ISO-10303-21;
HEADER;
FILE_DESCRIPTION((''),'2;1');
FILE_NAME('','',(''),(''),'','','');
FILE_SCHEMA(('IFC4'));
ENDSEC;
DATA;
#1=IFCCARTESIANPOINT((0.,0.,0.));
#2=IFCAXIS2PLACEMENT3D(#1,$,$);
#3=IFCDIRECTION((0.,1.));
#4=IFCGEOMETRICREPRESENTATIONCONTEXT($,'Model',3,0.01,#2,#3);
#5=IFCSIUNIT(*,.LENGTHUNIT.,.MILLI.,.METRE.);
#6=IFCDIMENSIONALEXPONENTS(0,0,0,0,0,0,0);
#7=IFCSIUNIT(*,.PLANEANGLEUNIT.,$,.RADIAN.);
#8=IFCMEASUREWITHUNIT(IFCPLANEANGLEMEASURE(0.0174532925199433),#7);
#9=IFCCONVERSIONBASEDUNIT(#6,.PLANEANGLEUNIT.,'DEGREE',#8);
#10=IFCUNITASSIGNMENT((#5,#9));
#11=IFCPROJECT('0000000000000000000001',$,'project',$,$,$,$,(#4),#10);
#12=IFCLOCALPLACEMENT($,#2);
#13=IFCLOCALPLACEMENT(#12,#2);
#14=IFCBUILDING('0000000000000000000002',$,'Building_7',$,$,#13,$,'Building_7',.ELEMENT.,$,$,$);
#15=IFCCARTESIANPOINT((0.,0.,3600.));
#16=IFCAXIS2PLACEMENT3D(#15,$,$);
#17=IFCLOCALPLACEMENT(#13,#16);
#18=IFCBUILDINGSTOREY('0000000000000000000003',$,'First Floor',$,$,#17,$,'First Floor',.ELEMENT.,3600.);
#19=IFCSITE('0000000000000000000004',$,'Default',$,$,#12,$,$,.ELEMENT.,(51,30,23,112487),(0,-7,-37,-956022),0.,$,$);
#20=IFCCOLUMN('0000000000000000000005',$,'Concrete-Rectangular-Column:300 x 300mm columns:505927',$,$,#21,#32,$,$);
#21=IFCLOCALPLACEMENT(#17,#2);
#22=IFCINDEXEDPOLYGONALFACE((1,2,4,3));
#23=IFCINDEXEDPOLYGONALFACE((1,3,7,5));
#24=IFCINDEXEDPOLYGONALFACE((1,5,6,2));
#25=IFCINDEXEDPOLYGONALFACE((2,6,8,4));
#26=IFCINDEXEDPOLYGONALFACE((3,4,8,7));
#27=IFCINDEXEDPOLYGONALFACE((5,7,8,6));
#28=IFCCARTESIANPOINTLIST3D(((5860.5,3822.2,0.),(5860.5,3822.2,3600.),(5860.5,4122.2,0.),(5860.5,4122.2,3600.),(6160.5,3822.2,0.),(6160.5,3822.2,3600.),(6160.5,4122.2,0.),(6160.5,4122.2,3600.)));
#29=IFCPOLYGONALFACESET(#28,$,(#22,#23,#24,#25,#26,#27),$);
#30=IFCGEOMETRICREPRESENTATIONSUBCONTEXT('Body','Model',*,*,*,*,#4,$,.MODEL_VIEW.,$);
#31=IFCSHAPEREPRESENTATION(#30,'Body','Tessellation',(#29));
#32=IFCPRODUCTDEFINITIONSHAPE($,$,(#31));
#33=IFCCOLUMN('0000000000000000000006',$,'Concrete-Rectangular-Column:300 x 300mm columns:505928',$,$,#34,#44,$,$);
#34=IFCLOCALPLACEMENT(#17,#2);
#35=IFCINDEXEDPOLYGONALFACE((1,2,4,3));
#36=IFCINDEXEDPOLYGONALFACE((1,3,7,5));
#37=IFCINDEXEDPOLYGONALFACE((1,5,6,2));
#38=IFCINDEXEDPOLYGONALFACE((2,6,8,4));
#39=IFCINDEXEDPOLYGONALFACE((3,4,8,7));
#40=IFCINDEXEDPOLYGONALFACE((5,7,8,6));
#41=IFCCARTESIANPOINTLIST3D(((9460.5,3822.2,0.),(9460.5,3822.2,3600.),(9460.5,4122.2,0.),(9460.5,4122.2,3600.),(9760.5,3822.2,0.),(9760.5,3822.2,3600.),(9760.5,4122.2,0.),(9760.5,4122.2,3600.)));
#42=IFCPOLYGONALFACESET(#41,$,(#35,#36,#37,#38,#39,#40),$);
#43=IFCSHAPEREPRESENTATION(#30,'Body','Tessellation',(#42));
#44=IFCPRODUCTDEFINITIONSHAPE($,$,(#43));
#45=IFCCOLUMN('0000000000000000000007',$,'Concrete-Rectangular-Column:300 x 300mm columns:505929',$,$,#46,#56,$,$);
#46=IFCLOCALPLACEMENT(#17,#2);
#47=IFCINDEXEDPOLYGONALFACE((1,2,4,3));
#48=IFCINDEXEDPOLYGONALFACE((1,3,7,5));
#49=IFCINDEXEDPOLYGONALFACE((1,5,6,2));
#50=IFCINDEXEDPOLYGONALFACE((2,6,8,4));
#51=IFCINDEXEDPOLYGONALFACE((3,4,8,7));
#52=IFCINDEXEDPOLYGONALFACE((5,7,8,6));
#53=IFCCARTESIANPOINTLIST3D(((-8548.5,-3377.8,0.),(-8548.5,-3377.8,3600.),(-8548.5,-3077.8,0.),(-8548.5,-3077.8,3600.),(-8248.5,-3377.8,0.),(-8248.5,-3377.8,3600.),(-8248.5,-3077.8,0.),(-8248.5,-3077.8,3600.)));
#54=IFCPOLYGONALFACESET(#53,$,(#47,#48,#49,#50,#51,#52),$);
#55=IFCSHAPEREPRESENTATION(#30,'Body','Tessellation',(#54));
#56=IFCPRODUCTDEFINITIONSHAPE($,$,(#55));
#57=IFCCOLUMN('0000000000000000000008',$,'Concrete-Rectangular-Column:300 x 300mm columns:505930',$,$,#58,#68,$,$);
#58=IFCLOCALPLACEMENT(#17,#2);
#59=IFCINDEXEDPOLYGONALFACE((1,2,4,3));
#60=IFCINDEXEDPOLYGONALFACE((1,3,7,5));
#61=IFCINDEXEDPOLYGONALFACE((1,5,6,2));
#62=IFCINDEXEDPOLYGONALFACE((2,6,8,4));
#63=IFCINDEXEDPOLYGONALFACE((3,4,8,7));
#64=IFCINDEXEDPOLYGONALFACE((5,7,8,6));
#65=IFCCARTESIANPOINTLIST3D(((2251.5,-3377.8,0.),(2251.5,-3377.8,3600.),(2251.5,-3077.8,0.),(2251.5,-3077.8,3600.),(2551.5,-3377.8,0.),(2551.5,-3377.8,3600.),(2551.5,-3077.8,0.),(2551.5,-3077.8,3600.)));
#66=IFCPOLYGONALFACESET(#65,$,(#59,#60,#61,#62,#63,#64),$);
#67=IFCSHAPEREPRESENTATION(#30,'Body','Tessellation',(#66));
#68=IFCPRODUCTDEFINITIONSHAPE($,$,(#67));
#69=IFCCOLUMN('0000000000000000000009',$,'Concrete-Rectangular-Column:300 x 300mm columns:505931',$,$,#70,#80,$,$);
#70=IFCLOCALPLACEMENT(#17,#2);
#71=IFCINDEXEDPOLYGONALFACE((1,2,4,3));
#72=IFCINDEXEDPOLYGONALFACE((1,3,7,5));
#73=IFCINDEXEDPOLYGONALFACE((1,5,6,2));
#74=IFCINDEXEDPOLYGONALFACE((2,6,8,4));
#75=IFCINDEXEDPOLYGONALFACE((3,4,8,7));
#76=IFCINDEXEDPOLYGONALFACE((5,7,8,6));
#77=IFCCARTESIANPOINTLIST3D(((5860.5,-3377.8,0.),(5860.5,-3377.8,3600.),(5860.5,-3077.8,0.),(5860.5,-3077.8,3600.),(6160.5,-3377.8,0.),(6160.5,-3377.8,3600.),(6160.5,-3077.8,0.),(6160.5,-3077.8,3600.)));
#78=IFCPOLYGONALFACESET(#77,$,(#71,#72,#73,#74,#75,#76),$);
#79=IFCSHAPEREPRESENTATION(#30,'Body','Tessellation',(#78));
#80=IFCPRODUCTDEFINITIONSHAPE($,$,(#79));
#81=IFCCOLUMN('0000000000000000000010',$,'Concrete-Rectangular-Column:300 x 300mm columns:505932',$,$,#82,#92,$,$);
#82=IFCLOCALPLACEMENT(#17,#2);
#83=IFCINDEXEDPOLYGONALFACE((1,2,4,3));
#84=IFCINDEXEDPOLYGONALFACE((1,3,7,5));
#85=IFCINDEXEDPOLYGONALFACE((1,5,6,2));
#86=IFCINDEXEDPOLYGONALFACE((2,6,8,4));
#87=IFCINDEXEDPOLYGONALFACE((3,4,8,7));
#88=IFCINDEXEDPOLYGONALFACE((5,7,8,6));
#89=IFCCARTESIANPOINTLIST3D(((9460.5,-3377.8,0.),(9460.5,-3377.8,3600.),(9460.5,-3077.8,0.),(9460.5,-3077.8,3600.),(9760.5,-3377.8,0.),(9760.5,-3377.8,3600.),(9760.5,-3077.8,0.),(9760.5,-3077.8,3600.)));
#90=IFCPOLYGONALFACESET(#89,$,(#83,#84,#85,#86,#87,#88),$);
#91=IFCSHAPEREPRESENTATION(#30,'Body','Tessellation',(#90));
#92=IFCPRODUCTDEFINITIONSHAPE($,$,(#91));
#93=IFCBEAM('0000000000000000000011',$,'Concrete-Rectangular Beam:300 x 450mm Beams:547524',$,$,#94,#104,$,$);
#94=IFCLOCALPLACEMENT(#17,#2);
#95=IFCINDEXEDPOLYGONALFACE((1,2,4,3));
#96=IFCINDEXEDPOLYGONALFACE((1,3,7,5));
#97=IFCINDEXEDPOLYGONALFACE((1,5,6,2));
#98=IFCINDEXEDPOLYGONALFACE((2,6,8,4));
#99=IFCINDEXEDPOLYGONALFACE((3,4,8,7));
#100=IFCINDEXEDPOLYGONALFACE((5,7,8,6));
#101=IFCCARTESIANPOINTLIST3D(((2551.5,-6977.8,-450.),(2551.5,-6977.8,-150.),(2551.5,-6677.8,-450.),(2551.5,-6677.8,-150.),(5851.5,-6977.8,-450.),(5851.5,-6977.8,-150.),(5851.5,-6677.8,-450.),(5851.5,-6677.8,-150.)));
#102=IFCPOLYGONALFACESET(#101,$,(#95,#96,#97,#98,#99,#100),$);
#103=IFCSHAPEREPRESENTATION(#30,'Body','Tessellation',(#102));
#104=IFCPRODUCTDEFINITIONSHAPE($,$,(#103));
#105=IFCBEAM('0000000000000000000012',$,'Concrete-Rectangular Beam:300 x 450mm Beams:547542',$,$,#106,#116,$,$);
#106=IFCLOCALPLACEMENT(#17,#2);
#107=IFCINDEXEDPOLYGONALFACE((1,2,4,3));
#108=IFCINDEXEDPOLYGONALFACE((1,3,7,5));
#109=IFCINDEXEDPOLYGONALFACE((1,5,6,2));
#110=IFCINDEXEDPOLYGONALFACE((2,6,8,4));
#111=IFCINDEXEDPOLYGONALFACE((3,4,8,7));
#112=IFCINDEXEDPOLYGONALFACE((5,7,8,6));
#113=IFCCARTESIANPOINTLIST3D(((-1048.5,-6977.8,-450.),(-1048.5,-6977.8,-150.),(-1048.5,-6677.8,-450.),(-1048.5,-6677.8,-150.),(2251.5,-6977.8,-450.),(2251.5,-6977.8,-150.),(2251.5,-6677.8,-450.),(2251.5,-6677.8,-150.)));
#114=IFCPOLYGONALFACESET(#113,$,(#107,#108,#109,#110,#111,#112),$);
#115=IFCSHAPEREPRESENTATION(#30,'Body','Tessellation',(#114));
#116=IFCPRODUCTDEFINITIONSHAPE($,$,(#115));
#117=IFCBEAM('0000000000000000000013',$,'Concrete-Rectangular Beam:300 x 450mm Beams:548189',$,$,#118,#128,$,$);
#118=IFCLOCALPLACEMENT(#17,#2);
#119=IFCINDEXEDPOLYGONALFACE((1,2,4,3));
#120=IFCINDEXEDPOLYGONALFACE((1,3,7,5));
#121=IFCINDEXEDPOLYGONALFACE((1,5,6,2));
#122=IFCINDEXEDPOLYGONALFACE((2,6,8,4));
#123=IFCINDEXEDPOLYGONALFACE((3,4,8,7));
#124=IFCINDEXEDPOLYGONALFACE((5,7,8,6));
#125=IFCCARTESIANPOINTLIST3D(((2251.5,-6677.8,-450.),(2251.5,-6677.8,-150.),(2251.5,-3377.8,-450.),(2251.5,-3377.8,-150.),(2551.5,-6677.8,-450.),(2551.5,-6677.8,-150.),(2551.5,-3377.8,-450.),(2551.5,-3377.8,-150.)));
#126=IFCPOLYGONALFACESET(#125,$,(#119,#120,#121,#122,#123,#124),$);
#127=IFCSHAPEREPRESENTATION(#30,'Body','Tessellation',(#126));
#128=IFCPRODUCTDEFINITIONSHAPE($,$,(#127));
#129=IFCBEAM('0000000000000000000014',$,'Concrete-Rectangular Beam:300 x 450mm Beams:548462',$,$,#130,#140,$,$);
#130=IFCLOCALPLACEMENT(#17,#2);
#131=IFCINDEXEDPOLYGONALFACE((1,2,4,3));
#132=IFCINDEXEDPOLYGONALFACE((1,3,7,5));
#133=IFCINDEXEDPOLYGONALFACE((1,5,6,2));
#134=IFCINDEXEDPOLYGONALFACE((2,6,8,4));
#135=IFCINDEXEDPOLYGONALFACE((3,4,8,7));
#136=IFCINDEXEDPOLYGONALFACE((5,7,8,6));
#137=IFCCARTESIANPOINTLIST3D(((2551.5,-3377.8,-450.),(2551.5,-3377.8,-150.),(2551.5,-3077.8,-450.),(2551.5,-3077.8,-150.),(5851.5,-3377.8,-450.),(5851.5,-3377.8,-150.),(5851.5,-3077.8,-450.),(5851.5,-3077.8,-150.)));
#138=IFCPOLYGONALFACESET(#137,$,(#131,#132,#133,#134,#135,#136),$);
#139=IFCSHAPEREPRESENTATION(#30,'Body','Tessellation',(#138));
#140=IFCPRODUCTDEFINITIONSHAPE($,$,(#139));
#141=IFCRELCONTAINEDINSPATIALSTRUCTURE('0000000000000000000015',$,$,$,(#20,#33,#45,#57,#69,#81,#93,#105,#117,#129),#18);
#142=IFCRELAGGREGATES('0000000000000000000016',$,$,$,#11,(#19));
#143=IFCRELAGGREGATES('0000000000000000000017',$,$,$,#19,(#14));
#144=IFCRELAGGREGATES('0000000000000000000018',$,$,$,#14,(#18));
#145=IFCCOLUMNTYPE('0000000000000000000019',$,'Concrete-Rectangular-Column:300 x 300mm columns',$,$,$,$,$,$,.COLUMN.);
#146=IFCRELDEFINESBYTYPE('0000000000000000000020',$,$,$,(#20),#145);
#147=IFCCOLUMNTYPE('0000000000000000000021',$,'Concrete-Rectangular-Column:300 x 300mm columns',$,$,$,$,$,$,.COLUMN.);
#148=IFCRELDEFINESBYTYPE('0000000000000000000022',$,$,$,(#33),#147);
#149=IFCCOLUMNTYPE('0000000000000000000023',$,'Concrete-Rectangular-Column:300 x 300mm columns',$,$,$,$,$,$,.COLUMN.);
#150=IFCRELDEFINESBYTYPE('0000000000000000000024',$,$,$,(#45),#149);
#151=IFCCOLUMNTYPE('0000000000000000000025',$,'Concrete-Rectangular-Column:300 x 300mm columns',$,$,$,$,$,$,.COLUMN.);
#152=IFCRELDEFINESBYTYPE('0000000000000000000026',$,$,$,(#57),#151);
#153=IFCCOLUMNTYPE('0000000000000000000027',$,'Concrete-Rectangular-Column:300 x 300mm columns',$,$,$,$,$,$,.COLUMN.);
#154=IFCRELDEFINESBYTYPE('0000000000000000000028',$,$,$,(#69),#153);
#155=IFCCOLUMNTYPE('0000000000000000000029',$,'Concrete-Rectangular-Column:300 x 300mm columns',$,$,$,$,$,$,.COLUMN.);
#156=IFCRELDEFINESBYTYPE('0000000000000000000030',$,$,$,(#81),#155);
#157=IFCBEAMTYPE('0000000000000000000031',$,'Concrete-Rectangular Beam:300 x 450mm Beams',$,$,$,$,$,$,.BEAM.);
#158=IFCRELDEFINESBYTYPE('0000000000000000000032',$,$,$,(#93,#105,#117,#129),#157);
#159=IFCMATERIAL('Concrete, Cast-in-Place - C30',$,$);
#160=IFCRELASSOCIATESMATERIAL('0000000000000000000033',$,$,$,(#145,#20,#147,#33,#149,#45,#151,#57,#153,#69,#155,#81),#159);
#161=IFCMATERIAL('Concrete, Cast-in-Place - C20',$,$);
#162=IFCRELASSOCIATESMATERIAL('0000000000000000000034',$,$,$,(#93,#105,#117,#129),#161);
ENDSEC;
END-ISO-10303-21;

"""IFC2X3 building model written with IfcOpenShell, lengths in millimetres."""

from ifc_helpers import new_model, entity, si_unit, converted_unit, direction, frame, frame_2d, origin, origin_2d_with_axis, place, context, subcontext, project, spatial, rectangle, extrude, source, transform, mapped, material, type_object, type_shapes, element, save


model = new_model("IFC2X3")

# Units and contexts
model_context = context("Model", 3, precision=0.01, world=origin(), true_north=direction((0.0, 1.0)))
body_context = subcontext(model_context, "Body", "Model", "MODEL_VIEW")
ifc_project = project(units=[si_unit("LENGTHUNIT", "METRE", prefix="MILLI"), converted_unit("PLANEANGLEUNIT", "DEGREE", entity("IfcPlaneAngleMeasure", 0.0174532925199433), si_unit("PLANEANGLEUNIT", "RADIAN"), dimensions=[0, 0, 0, 0, 0, 0, 0])], contexts=[model_context])

# Site, building, storey
site_placement = place(None, origin())
site = spatial("IfcSite", under=ifc_project, at=site_placement, Name="Default", CompositionType="ELEMENT", RefLatitude=(51, 30, 23, 112487), RefLongitude=(0, -7, -37, -956022), RefElevation=0.0)
building_placement = place(site_placement, origin())
building = spatial("IfcBuilding", under=site, at=building_placement, Name="Building_7", LongName="Building_7", CompositionType="ELEMENT")
storey_placement = place(building_placement, frame((0.0, 0.0, 3600.0)))
storey = spatial("IfcBuildingStorey", under=building, at=storey_placement, Name="First Floor", LongName="First Floor", CompositionType="ELEMENT", Elevation=3600.0)

# Columns
ifc_material_1 = material(Name="Concrete, Cast-in-Place - C30")
column_type_1 = type_object("IfcColumnType", Name="Concrete-Rectangular-Column:300 x 300mm columns", PredefinedType="COLUMN", material=ifc_material_1)
shared_shape_1 = source(origin(), body_context, "Body", "SweptSolid", [
    extrude(rectangle(XDim=300.0, YDim=300.0, at=frame_2d((0.0, 0.0), x_axis=(1.0, 0.0))), frame((6010.5, 3972.2, 3600.0), z_axis=(0.0, 0.0, 1.0), x_axis=(-1.0, 0.0, 0.0)), (0.0, 0.0, 1.0), 3600.0),
])
type_shapes(column_type_1, [shared_shape_1])
column_1_placement = place(storey_placement, frame((0.0, 0.0, -3600.0)))
element("IfcColumn", 1, at=column_1_placement, inside=storey, type_object=column_type_1, material=ifc_material_1, Name="Concrete-Rectangular-Column:300 x 300mm columns:505927", context=body_context, shape_type="MappedRepresentation", body=[
    mapped(shared_shape_1, transform((0.0, 0.0, 0.0), scale=1.0)),
])
column_type_2 = type_object("IfcColumnType", Name="Concrete-Rectangular-Column:300 x 300mm columns", PredefinedType="COLUMN", material=ifc_material_1)
shared_shape_2 = source(origin(), body_context, "Body", "SweptSolid", [
    extrude(rectangle(XDim=300.0, YDim=300.0, at=frame_2d((0.0, 0.0), x_axis=(1.0, 0.0))), frame((9610.5, 3972.2, 3600.0), z_axis=(0.0, 0.0, 1.0), x_axis=(-1.0, 0.0, 0.0)), (0.0, 0.0, 1.0), 3600.0),
])
type_shapes(column_type_2, [shared_shape_2])
column_2_placement = place(storey_placement, frame((0.0, 0.0, -3600.0)))
element("IfcColumn", 2, at=column_2_placement, inside=storey, type_object=column_type_2, material=ifc_material_1, Name="Concrete-Rectangular-Column:300 x 300mm columns:505928", context=body_context, shape_type="MappedRepresentation", body=[
    mapped(shared_shape_2, transform((0.0, 0.0, 0.0), scale=1.0)),
])
column_type_3 = type_object("IfcColumnType", Name="Concrete-Rectangular-Column:300 x 300mm columns", PredefinedType="COLUMN", material=ifc_material_1)
shared_shape_3 = source(origin(), body_context, "Body", "SweptSolid", [
    extrude(rectangle(XDim=300.0, YDim=300.0, at=frame_2d((0.0, 0.0), x_axis=(1.0, 0.0))), frame((-8398.5, -3227.8, 3600.0), z_axis=(0.0, 0.0, 1.0), x_axis=(-1.0, 0.0, 0.0)), (0.0, 0.0, 1.0), 3600.0),
])
type_shapes(column_type_3, [shared_shape_3])
column_3_placement = place(storey_placement, frame((0.0, 0.0, -3600.0)))
element("IfcColumn", 3, at=column_3_placement, inside=storey, type_object=column_type_3, material=ifc_material_1, Name="Concrete-Rectangular-Column:300 x 300mm columns:505929", context=body_context, shape_type="MappedRepresentation", body=[
    mapped(shared_shape_3, transform((0.0, 0.0, 0.0), scale=1.0)),
])
column_type_4 = type_object("IfcColumnType", Name="Concrete-Rectangular-Column:300 x 300mm columns", PredefinedType="COLUMN", material=ifc_material_1)
shared_shape_4 = source(origin(), body_context, "Body", "SweptSolid", [
    extrude(rectangle(XDim=300.0, YDim=300.0, at=origin_2d_with_axis()), frame((2401.5, -3227.8, 3600.0), z_axis=(0.0, 0.0, 1.0), x_axis=(-1.0, 0.0, 0.0)), (0.0, 0.0, 1.0), 3600.0),
])
type_shapes(column_type_4, [shared_shape_4])
column_4_placement = place(storey_placement, frame((0.0, 0.0, -3600.0)))
element("IfcColumn", 4, at=column_4_placement, inside=storey, type_object=column_type_4, material=ifc_material_1, Name="Concrete-Rectangular-Column:300 x 300mm columns:505930", context=body_context, shape_type="MappedRepresentation", body=[
    mapped(shared_shape_4, transform((0.0, 0.0, 0.0), scale=1.0)),
])
column_type_5 = type_object("IfcColumnType", Name="Concrete-Rectangular-Column:300 x 300mm columns", PredefinedType="COLUMN", material=ifc_material_1)
shared_shape_5 = source(origin(), body_context, "Body", "SweptSolid", [
    extrude(rectangle(XDim=300.0, YDim=300.0, at=frame_2d((0.0, 0.0), x_axis=(1.0, 0.0))), frame((6010.5, -3227.8, 3600.0), z_axis=(0.0, 0.0, 1.0), x_axis=(-1.0, 0.0, 0.0)), (0.0, 0.0, 1.0), 3600.0),
])
type_shapes(column_type_5, [shared_shape_5])
column_5_placement = place(storey_placement, frame((0.0, 0.0, -3600.0)))
element("IfcColumn", 5, at=column_5_placement, inside=storey, type_object=column_type_5, material=ifc_material_1, Name="Concrete-Rectangular-Column:300 x 300mm columns:505931", context=body_context, shape_type="MappedRepresentation", body=[
    mapped(shared_shape_5, transform((0.0, 0.0, 0.0), scale=1.0)),
])
column_type_6 = type_object("IfcColumnType", Name="Concrete-Rectangular-Column:300 x 300mm columns", PredefinedType="COLUMN", material=ifc_material_1)
shared_shape_6 = source(origin(), body_context, "Body", "SweptSolid", [
    extrude(rectangle(XDim=300.0, YDim=300.0, at=frame_2d((0.0, 0.0), x_axis=(1.0, 0.0))), frame((9610.5, -3227.8, 3600.0), z_axis=(0.0, 0.0, 1.0), x_axis=(-1.0, 0.0, 0.0)), (0.0, 0.0, 1.0), 3600.0),
])
type_shapes(column_type_6, [shared_shape_6])
column_6_placement = place(storey_placement, frame((0.0, 0.0, -3600.0)))
element("IfcColumn", 6, at=column_6_placement, inside=storey, type_object=column_type_6, material=ifc_material_1, Name="Concrete-Rectangular-Column:300 x 300mm columns:505932", context=body_context, shape_type="MappedRepresentation", body=[
    mapped(shared_shape_6, transform((0.0, 0.0, 0.0), scale=1.0)),
])

# Beams
ifc_material_2 = material(Name="Concrete, Cast-in-Place - C20")
beam_type = type_object("IfcBeamType", Name="Concrete-Rectangular Beam:300 x 450mm Beams", PredefinedType="BEAM")
beam_1_placement = place(storey_placement, frame((6001.5, -6827.8, 0.0), z_axis=(0.0, 0.0, 1.0), x_axis=(-1.0, 0.0, 0.0)))
element("IfcBeam", 7, at=beam_1_placement, inside=storey, type_object=beam_type, material=ifc_material_2, Name="Concrete-Rectangular Beam:300 x 450mm Beams:547524", context=body_context, shape_type="SweptSolid", body=[
    extrude(rectangle(XDim=300.0, YDim=300.0, at=frame_2d((0.0, 0.0), x_axis=(1.0, 0.0))), frame((150.0, 0.0, -300.0), z_axis=(1.0, 0.0, 0.0), x_axis=(0.0, 0.0, -1.0)), (0.0, 0.0, 1.0), 3300.0),
])
beam_2_placement = place(storey_placement, frame((2401.5, -6827.8, 0.0), z_axis=(0.0, 0.0, 1.0), x_axis=(-1.0, 0.0, 0.0)))
element("IfcBeam", 8, at=beam_2_placement, inside=storey, type_object=beam_type, material=ifc_material_2, Name="Concrete-Rectangular Beam:300 x 450mm Beams:547542", context=body_context, shape_type="SweptSolid", body=[
    extrude(rectangle(XDim=300.0, YDim=300.0, at=frame_2d((0.0, 0.0), x_axis=(1.0, 0.0))), frame((150.0, 0.0, -300.0), z_axis=(1.0, 0.0, 0.0), x_axis=(0.0, 0.0, -1.0)), (0.0, 0.0, 1.0), 3300.0),
])
beam_3_placement = place(storey_placement, frame((2401.5, -3227.8, 0.0), z_axis=(0.0, 0.0, 1.0), x_axis=(0.0, -1.0, 0.0)))
element("IfcBeam", 9, at=beam_3_placement, inside=storey, type_object=beam_type, material=ifc_material_2, Name="Concrete-Rectangular Beam:300 x 450mm Beams:548189", context=body_context, shape_type="SweptSolid", body=[
    extrude(rectangle(XDim=300.0, YDim=300.0, at=origin_2d_with_axis()), frame((150.0, 0.0, -300.0), z_axis=(1.0, 0.0, 0.0), x_axis=(0.0, 0.0, -1.0)), (0.0, 0.0, 1.0), 3300.0),
])
beam_4_placement = place(storey_placement, frame((6001.5, -3227.8, 0.0), z_axis=(0.0, 0.0, 1.0), x_axis=(-1.0, 0.0, 0.0)))
element("IfcBeam", 10, at=beam_4_placement, inside=storey, type_object=beam_type, material=ifc_material_2, Name="Concrete-Rectangular Beam:300 x 450mm Beams:548462", context=body_context, shape_type="SweptSolid", body=[
    extrude(rectangle(XDim=300.0, YDim=300.0, at=frame_2d((0.0, 0.0), x_axis=(1.0, 0.0))), frame((150.0, 0.0, -300.0), z_axis=(1.0, 0.0, 0.0), x_axis=(0.0, 0.0, -1.0)), (0.0, 0.0, 1.0), 3300.0),
])

save(model, "model.ifc")
